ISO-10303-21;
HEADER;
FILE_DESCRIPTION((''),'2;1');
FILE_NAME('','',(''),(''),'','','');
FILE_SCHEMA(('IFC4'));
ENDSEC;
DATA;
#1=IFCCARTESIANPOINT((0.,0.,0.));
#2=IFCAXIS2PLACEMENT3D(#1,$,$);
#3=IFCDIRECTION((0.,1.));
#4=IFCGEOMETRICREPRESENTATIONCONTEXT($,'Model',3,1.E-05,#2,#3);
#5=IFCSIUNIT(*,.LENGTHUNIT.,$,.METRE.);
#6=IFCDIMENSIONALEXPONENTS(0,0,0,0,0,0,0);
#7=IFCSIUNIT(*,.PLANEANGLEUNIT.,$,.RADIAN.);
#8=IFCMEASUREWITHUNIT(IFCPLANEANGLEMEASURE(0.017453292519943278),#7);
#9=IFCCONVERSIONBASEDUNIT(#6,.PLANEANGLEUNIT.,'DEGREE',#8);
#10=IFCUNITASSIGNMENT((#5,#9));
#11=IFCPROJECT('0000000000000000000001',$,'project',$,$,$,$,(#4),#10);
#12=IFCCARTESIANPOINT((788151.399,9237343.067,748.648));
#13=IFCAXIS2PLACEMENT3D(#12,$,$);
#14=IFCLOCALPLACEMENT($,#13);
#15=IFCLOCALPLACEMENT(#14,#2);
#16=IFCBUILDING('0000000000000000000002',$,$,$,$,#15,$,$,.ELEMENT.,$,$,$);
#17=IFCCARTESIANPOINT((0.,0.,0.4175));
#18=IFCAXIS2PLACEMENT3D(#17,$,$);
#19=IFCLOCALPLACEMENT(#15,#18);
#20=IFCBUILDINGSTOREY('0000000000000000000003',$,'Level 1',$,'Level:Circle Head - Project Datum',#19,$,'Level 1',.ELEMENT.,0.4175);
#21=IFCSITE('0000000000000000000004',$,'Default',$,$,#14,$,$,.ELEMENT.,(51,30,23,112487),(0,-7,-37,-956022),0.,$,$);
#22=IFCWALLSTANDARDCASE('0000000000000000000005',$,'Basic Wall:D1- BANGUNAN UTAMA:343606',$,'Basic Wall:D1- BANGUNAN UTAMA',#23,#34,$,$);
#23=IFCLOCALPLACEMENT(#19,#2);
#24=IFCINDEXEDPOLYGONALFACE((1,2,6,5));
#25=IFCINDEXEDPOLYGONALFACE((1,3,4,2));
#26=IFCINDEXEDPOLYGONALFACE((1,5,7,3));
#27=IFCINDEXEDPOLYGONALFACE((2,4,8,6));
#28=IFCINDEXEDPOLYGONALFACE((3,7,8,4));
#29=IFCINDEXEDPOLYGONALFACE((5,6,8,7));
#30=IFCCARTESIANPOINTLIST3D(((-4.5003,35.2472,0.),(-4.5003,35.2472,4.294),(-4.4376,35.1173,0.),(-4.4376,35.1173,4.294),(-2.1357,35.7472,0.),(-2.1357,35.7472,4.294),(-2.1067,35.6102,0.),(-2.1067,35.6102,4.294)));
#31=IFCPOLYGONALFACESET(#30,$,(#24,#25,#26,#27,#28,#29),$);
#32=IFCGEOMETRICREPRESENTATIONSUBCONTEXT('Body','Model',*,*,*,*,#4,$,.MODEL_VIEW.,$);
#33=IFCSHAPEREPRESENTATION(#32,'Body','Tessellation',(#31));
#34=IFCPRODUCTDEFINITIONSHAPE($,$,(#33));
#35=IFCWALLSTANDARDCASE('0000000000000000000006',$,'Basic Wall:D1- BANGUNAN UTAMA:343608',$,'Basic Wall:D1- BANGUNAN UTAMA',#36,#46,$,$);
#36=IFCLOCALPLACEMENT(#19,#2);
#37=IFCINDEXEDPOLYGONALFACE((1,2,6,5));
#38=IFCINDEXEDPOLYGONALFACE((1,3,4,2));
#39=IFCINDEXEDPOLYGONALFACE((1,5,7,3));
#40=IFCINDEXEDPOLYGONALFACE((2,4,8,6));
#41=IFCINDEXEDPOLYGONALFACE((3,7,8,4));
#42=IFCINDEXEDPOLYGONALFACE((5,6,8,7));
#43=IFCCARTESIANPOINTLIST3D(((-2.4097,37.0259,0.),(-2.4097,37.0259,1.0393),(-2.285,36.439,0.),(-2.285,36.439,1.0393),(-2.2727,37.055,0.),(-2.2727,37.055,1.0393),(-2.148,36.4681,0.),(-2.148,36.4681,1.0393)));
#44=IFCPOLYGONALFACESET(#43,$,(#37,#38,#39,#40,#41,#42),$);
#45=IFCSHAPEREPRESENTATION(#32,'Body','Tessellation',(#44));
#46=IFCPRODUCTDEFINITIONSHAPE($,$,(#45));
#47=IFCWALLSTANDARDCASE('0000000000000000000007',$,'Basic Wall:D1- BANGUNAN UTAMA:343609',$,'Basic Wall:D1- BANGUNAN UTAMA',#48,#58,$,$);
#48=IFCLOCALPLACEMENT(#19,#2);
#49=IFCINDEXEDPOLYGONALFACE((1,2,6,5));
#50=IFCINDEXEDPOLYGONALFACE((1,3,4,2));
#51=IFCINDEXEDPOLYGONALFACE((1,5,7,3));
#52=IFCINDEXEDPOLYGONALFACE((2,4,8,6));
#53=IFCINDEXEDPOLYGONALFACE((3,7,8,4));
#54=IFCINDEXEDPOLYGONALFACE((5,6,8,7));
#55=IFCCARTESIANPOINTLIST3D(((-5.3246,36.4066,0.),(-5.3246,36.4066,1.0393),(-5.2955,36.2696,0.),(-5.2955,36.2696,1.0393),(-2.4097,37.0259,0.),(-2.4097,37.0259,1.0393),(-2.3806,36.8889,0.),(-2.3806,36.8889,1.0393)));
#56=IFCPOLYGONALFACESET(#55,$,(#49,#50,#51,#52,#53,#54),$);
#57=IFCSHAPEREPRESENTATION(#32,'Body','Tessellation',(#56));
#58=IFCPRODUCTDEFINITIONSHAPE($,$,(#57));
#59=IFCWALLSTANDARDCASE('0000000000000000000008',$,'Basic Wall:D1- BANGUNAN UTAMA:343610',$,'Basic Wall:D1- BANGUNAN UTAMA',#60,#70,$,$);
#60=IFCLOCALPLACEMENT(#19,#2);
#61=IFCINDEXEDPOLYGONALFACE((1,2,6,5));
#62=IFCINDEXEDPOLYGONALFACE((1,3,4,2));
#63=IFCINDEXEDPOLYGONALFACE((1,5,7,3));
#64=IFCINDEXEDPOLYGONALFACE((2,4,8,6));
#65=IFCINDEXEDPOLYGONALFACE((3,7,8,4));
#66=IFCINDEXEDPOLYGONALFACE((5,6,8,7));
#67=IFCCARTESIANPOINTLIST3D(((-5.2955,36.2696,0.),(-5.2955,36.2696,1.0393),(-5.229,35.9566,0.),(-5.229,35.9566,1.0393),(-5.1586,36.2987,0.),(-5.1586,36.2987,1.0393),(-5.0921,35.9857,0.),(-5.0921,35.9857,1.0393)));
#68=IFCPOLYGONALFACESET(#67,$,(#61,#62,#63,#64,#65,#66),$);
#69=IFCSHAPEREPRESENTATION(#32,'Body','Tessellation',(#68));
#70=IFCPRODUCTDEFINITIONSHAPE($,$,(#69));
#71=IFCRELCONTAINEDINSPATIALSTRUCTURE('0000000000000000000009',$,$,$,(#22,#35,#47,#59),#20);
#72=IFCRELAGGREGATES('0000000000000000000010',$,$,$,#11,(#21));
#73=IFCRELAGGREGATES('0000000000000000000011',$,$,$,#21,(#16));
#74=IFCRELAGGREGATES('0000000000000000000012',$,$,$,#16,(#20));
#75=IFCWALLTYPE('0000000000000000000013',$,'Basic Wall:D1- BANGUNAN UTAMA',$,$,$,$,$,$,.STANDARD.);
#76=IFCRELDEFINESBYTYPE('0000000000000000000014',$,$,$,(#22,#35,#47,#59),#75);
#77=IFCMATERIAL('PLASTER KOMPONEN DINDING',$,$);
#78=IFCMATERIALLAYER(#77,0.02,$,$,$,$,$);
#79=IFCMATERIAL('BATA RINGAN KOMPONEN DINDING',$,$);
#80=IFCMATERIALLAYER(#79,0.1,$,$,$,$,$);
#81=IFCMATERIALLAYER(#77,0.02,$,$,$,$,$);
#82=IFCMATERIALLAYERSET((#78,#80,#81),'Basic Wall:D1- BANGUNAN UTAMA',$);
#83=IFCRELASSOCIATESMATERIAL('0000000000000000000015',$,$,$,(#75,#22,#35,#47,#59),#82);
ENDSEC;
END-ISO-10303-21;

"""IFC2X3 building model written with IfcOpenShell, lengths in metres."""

from ifc_helpers import new_model, entity, si_unit, converted_unit, direction, frame, frame_2d, origin, place, context, subcontext, project, spatial, polyline, rectangle, outline, extrude, material, layer, layer_set, layer_usage, type_object, element, save


model = new_model("IFC2X3")

# Units and contexts
model_context = context("Model", 3, precision=1e-05, world=origin(), true_north=direction((0.0, 1.0)))
body_context = subcontext(model_context, "Body", "Model", "MODEL_VIEW")
ifc_project = project(units=[si_unit("LENGTHUNIT", "METRE"), converted_unit("PLANEANGLEUNIT", "DEGREE", entity("IfcPlaneAngleMeasure", 0.017453292519943278), si_unit("PLANEANGLEUNIT", "RADIAN"), dimensions=[0, 0, 0, 0, 0, 0, 0])], contexts=[model_context])

# Site, building, storey
site_placement = place(None, frame((788151.399, 9237343.067, 748.648)))
site = spatial("IfcSite", under=ifc_project, at=site_placement, Name="Default", CompositionType="ELEMENT", RefLatitude=(51, 30, 23, 112487), RefLongitude=(0, -7, -37, -956022), RefElevation=0.0)
building_placement = place(site_placement, origin())
building = spatial("IfcBuilding", under=site, at=building_placement, CompositionType="ELEMENT")
storey_placement = place(building_placement, frame((0.0, 0.0, 0.4175)))
storey = spatial("IfcBuildingStorey", under=building, at=storey_placement, Name="Level 1", ObjectType="Level:Circle Head - Project Datum", LongName="Level 1", CompositionType="ELEMENT", Elevation=0.4175)

# Walls
ifc_material_1 = material(Name="PLASTER KOMPONEN DINDING")
ifc_layer_1 = layer(ifc_material_1, 0.02)
ifc_material_2 = material(Name="BATA RINGAN KOMPONEN DINDING")
ifc_layer_2 = layer(ifc_material_2, 0.1)
ifc_layer_3 = layer(ifc_material_1, 0.02)
ifc_layer_set = layer_set([ifc_layer_1, ifc_layer_2, ifc_layer_3], Name="Basic Wall:D1- BANGUNAN UTAMA")
wall_type = type_object("IfcWallType", Name="Basic Wall:D1- BANGUNAN UTAMA", PredefinedType="STANDARD", material=ifc_layer_set)
ifc_layer_usage_1 = layer_usage(ifc_layer_set, "AXIS2", "POSITIVE", -0.07)
wall_1_placement = place(storey_placement, frame((-2.1212, 35.6787, 0.0), z_axis=(0.0, 0.0, 1.0), x_axis=(-0.978363, -0.206896, 0.0)))
element("IfcWallStandardCase", 1, at=wall_1_placement, inside=storey, type_object=wall_type, material=ifc_layer_usage_1, Name="Basic Wall:D1- BANGUNAN UTAMA:343606", ObjectType="Basic Wall:D1- BANGUNAN UTAMA", context=body_context, shape_type="SweptSolid", body=[
    extrude(outline(polyline([(2.4169, -0.07), (2.3824, 0.07), (0.0, 0.07), (0.0, -0.07), (2.4169, -0.07)])), origin(), (0.0, 0.0, 1.0), 4.294),
])
ifc_layer_usage_2 = layer_usage(ifc_layer_set, "AXIS2", "POSITIVE", -0.07)
wall_2_placement = place(storey_placement, frame((-2.2165, 36.4535, 0.0), z_axis=(0.0, 0.0, 1.0), x_axis=(-0.207813, 0.978168, 0.0)))
element("IfcWallStandardCase", 2, at=wall_2_placement, inside=storey, type_object=wall_type, material=ifc_layer_usage_2, Name="Basic Wall:D1- BANGUNAN UTAMA:343608", ObjectType="Basic Wall:D1- BANGUNAN UTAMA", context=body_context, shape_type="SweptSolid", body=[
    extrude(rectangle(XDim=0.6, YDim=0.14, at=frame_2d((0.3, 0.0), x_axis=(-1.0, 0.0))), origin(), (0.0, 0.0, 1.0), 1.0393),
])
ifc_layer_usage_3 = layer_usage(ifc_layer_set, "AXIS2", "POSITIVE", -0.07)
wall_3_placement = place(storey_placement, frame((-2.3951, 36.9574, 0.0), z_axis=(0.0, 0.0, 1.0), x_axis=(-0.978168, -0.207813, 0.0)))
element("IfcWallStandardCase", 3, at=wall_3_placement, inside=storey, type_object=wall_type, material=ifc_layer_usage_3, Name="Basic Wall:D1- BANGUNAN UTAMA:343609", ObjectType="Basic Wall:D1- BANGUNAN UTAMA", context=body_context, shape_type="SweptSolid", body=[
    extrude(rectangle(XDim=2.98, YDim=0.14, at=frame_2d((1.49, 0.0), x_axis=(-1.0, 0.0))), origin(), (0.0, 0.0, 1.0), 1.0393),
])
ifc_layer_usage_4 = layer_usage(ifc_layer_set, "AXIS2", "POSITIVE", -0.07)
wall_4_placement = place(storey_placement, frame((-5.227, 36.2842, 0.0), z_axis=(0.0, 0.0, 1.0), x_axis=(0.207813, -0.978168, 0.0)))
element("IfcWallStandardCase", 4, at=wall_4_placement, inside=storey, type_object=wall_type, material=ifc_layer_usage_4, Name="Basic Wall:D1- BANGUNAN UTAMA:343610", ObjectType="Basic Wall:D1- BANGUNAN UTAMA", context=body_context, shape_type="SweptSolid", body=[
    extrude(rectangle(XDim=0.32, YDim=0.14, at=frame_2d((0.16, 0.0), x_axis=(-1.0, 0.0))), origin(), (0.0, 0.0, 1.0), 1.0393),
])

save(model, "model.ifc")
